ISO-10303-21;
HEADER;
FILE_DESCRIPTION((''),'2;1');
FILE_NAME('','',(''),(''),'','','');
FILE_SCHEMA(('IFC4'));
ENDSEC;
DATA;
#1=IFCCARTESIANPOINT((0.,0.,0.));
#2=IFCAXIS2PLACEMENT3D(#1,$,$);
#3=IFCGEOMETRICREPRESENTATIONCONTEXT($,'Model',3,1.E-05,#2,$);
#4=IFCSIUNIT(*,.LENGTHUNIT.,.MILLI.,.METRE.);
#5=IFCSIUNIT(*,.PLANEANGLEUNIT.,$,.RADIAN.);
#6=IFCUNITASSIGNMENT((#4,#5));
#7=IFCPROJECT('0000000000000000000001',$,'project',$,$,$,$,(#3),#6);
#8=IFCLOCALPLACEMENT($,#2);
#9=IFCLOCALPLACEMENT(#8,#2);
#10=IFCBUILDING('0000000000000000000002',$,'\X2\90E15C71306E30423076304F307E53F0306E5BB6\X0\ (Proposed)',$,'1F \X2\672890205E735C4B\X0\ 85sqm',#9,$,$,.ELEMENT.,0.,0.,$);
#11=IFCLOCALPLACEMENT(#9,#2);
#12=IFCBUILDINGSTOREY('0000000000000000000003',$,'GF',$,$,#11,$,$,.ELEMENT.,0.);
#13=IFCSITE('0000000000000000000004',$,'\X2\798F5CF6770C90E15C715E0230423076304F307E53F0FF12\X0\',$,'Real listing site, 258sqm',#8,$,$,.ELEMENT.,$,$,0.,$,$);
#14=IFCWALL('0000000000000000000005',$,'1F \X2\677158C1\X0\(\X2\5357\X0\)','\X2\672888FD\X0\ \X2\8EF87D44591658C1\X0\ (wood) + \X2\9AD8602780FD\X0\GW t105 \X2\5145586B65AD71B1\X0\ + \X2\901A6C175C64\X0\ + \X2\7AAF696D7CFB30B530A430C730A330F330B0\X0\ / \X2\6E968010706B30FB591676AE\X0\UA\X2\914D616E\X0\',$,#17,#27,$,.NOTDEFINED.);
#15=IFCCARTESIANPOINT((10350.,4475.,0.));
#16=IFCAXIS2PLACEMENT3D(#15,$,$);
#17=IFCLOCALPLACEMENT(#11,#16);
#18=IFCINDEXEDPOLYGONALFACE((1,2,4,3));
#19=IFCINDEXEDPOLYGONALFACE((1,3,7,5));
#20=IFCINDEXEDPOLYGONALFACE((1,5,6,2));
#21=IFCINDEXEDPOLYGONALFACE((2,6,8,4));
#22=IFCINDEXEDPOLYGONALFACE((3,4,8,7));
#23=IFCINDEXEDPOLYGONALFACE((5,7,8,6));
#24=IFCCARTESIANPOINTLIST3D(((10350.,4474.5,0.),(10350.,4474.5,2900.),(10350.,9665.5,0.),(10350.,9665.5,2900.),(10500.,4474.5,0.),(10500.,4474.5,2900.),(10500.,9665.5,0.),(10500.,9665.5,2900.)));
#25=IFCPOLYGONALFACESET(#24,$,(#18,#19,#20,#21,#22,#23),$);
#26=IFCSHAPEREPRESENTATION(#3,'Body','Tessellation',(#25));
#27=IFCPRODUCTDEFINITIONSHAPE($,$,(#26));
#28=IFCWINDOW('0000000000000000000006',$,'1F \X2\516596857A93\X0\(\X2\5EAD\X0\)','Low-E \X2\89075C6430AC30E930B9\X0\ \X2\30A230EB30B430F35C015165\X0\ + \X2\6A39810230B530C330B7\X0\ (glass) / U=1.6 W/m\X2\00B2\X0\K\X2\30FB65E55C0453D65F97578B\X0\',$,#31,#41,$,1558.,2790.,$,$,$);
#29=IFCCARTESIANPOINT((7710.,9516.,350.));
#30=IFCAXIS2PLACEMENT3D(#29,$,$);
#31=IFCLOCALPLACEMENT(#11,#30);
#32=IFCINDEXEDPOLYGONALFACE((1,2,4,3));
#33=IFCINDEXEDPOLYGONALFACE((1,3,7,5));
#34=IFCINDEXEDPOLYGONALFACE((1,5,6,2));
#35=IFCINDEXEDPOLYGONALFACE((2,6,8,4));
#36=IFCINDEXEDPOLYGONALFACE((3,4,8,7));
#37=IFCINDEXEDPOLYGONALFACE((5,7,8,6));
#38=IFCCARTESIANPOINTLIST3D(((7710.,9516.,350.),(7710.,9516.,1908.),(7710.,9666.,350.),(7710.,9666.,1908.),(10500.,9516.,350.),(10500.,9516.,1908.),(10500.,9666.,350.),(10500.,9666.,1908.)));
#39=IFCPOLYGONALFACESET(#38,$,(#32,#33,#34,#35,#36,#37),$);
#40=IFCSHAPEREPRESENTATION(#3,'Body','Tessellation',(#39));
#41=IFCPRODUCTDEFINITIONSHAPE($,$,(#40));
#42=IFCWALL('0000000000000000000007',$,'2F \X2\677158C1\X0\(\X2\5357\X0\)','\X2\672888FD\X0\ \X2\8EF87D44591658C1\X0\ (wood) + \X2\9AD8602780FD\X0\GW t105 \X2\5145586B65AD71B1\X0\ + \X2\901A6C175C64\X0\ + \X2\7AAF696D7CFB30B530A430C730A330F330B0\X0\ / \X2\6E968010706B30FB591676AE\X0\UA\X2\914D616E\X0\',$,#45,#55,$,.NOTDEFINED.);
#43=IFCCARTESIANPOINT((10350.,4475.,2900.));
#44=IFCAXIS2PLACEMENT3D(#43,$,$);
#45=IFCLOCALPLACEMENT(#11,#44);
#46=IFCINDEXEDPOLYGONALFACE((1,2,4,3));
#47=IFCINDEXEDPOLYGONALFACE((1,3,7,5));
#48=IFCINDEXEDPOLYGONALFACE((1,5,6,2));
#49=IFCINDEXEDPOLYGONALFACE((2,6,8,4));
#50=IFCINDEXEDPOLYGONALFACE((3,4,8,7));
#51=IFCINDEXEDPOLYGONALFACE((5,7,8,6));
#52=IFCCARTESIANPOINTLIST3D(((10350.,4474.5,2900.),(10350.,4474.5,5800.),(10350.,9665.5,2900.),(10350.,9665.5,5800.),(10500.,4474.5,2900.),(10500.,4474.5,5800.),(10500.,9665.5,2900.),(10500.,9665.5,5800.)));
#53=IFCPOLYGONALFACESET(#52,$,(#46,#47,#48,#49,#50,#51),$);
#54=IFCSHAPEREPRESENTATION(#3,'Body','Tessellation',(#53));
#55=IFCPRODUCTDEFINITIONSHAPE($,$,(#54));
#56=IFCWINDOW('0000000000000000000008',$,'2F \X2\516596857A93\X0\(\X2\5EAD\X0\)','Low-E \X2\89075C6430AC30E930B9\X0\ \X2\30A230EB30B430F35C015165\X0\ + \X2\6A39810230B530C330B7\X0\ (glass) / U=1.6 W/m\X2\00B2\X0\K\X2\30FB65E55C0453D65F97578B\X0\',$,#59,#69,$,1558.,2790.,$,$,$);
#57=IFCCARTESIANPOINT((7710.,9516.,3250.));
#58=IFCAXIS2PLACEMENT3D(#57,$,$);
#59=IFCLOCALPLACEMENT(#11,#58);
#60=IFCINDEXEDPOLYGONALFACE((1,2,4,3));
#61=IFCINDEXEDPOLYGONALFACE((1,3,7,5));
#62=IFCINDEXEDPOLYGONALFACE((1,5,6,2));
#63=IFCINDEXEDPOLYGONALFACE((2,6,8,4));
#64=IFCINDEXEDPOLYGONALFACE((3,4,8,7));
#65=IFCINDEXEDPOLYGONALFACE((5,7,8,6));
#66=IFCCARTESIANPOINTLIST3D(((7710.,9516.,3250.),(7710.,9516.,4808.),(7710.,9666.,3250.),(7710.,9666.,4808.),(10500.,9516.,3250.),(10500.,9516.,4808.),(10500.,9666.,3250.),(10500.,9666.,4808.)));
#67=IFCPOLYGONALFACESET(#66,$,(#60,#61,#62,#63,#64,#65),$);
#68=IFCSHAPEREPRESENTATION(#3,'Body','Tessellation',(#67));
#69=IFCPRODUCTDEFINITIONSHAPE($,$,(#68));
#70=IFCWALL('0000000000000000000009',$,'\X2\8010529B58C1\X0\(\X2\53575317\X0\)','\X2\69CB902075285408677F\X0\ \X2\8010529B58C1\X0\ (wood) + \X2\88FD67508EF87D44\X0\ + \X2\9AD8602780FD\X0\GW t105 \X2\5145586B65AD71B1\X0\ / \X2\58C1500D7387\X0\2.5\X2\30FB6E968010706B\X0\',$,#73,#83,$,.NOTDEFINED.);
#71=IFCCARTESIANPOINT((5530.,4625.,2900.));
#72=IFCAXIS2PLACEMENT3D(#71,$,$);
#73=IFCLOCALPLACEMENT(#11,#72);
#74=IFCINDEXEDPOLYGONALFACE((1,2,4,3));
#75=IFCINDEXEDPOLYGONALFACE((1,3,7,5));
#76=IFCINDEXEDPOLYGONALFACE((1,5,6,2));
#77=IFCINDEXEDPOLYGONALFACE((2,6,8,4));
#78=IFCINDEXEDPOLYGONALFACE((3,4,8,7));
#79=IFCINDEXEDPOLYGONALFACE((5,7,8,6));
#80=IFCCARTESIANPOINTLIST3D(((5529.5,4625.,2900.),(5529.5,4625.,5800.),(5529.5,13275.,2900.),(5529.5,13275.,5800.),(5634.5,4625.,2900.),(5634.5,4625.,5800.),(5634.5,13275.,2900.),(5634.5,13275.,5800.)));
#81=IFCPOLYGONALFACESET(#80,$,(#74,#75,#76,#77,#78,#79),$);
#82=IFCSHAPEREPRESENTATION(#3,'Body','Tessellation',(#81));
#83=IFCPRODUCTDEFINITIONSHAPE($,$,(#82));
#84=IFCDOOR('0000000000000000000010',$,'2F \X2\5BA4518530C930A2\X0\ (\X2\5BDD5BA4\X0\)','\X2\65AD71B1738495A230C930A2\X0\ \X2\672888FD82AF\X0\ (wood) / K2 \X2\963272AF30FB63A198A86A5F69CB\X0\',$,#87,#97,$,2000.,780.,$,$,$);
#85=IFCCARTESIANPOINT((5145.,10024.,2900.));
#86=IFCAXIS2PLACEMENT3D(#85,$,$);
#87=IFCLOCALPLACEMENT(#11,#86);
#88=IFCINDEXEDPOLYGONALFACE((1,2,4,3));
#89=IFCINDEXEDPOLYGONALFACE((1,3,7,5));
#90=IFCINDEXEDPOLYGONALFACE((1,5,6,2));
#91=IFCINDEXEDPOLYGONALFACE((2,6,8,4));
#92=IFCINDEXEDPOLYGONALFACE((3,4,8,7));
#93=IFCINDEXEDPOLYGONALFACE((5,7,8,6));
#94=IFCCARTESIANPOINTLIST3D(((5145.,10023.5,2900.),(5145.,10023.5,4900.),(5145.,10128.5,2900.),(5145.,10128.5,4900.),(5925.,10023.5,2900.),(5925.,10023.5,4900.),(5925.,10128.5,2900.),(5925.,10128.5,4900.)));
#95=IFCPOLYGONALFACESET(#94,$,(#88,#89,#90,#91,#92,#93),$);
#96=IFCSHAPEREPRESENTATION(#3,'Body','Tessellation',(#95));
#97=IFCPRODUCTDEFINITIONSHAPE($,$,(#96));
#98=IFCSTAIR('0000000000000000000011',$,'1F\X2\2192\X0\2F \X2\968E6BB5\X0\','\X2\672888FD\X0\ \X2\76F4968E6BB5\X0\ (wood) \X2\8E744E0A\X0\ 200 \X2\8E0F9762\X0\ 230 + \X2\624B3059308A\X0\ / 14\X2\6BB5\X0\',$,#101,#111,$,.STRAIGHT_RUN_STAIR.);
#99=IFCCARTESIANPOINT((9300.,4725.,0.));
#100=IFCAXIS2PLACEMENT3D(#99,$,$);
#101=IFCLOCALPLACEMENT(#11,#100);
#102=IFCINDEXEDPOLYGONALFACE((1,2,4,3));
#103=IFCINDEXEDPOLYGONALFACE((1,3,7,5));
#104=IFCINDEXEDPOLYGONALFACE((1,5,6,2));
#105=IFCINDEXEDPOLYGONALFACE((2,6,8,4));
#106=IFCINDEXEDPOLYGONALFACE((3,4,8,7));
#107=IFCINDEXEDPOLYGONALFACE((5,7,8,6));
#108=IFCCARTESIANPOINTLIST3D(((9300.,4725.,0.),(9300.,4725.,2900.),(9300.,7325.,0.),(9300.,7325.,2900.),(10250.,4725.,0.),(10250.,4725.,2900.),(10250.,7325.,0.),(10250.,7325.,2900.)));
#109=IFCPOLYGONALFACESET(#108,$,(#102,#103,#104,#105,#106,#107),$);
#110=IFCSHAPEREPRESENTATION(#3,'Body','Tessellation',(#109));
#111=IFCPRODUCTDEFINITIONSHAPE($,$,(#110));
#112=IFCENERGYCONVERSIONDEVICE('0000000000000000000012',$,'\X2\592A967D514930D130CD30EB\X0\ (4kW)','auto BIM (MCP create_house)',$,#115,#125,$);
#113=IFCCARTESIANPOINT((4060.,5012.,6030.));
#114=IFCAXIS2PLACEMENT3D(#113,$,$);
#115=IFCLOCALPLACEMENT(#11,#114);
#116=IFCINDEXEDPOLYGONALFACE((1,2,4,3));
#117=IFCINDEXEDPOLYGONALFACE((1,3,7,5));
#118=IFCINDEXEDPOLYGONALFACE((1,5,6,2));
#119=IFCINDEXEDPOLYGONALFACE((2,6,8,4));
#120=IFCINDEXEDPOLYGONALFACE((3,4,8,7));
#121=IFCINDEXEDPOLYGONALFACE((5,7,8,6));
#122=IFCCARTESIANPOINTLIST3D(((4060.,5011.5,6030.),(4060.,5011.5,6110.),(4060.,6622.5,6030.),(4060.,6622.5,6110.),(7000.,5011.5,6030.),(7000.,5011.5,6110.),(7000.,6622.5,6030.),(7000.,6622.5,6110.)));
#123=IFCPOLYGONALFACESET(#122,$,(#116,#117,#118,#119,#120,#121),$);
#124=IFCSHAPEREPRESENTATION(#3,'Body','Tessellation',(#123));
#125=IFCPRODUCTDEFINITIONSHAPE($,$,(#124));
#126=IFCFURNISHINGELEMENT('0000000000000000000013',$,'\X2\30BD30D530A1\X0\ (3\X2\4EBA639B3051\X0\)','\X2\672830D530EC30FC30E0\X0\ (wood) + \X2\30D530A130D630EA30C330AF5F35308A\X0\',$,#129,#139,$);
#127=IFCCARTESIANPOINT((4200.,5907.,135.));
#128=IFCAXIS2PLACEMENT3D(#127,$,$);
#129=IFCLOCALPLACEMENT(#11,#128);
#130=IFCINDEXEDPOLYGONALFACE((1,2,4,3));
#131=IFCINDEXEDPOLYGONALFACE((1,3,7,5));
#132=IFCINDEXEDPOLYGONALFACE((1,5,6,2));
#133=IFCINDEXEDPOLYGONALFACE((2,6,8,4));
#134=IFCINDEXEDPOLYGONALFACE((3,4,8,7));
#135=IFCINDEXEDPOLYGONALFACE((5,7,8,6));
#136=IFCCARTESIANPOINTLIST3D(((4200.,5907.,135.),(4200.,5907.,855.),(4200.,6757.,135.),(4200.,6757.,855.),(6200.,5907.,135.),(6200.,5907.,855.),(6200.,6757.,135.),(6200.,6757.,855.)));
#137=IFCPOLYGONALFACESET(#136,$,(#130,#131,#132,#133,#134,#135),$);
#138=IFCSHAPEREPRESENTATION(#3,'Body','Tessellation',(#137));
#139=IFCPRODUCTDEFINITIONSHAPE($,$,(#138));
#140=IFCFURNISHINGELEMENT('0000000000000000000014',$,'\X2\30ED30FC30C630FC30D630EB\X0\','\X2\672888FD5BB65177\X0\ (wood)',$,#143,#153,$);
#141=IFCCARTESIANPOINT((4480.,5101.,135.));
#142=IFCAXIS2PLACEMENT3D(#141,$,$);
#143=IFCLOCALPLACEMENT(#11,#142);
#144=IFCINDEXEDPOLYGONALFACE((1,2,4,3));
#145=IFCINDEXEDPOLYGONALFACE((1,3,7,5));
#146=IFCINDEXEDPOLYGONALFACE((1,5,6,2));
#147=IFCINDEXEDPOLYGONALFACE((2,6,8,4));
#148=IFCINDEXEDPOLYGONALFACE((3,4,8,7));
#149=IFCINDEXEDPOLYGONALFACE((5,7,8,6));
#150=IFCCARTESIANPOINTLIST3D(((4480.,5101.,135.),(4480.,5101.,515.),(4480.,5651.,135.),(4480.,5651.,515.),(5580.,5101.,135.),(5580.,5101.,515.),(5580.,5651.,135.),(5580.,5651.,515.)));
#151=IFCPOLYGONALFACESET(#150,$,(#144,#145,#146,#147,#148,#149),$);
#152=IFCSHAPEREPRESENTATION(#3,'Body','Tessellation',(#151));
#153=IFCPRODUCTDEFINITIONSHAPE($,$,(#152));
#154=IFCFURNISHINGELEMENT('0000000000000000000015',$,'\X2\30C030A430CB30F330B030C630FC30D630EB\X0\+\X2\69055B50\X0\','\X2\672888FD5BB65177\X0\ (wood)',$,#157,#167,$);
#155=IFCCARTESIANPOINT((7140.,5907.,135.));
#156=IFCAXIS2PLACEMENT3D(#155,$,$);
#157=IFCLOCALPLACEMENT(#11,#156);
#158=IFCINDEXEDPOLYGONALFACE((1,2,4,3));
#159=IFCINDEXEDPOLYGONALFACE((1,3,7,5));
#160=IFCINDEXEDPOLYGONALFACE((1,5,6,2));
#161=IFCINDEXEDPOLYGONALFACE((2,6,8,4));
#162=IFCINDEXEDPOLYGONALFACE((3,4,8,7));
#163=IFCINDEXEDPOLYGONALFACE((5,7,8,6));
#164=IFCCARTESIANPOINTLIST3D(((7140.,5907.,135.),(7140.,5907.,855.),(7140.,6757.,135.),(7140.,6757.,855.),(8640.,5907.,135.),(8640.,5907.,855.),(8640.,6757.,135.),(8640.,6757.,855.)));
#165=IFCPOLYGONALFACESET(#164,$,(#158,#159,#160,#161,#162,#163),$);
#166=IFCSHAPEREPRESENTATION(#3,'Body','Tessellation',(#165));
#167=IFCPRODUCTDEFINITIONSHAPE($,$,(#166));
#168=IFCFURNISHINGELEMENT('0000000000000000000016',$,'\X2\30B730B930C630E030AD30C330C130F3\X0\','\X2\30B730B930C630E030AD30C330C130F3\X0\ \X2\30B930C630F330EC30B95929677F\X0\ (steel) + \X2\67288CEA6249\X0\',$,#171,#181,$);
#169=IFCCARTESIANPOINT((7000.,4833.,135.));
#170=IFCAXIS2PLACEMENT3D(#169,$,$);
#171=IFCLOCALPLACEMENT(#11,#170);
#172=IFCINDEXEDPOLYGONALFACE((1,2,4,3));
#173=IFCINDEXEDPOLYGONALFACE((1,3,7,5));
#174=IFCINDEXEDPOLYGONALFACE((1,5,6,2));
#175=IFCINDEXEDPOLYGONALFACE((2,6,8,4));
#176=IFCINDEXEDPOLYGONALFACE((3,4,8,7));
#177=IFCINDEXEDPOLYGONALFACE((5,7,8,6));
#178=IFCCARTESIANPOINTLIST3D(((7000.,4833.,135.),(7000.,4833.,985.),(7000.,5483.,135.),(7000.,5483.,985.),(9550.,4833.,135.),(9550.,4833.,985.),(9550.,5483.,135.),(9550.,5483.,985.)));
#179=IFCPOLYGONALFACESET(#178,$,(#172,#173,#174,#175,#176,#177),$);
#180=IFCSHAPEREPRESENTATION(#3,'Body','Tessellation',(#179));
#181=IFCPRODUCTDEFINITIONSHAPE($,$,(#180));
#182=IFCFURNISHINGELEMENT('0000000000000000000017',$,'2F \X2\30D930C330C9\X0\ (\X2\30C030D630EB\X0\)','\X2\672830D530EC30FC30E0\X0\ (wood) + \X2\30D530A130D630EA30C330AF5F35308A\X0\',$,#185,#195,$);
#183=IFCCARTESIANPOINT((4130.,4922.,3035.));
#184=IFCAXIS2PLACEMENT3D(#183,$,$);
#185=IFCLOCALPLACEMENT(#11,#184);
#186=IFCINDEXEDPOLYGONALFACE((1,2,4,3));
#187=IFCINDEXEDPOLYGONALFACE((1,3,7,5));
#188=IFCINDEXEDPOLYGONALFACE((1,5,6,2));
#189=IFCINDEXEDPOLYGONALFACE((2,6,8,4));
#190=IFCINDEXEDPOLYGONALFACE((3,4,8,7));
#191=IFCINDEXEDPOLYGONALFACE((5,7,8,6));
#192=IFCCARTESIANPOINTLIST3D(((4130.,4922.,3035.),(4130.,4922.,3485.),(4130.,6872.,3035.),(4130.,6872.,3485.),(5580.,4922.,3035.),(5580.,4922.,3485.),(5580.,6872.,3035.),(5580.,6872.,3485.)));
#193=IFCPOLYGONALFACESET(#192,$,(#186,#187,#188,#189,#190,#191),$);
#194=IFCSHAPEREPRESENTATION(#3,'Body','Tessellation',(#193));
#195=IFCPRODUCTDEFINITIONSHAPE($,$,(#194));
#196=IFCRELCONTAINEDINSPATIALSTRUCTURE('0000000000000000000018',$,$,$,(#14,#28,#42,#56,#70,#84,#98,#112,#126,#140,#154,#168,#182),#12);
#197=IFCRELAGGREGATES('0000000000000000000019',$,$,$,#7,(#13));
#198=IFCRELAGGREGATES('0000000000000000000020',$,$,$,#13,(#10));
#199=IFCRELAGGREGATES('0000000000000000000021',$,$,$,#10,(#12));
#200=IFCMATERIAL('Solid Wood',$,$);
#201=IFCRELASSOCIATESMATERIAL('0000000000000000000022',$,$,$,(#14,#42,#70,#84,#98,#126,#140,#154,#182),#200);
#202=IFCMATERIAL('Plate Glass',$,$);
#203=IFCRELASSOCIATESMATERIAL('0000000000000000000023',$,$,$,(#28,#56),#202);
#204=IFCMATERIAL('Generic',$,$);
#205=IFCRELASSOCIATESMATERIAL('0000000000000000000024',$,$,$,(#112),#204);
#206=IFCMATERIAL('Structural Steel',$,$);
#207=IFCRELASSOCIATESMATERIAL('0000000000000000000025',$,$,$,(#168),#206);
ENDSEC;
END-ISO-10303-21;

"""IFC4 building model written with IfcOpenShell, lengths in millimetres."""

from ifc_helpers import new_model, si_unit, frame, frame_2d, origin, place, context, project, spatial, rectangle, extrude, material, element, fill, save


model = new_model("IFC4")

# Units and contexts
model_context = context("Model", 3, precision=1e-05, world=origin())
ifc_project = project(units=[si_unit("LENGTHUNIT", "METRE", prefix="MILLI"), si_unit("PLANEANGLEUNIT", "RADIAN")], contexts=[model_context])

# Site, building, storey
site_placement = place(None, origin())
site = spatial("IfcSite", under=ifc_project, at=site_placement, Name="福島県郡山市あぶくま台２", ObjectType="Real listing site, 258sqm", CompositionType="ELEMENT", RefElevation=0.0)
building_placement = place(site_placement, origin())
building = spatial("IfcBuilding", under=site, at=building_placement, Name="郡山のあぶくま台の家 (Proposed)", ObjectType="1F 木造平屋 85sqm", CompositionType="ELEMENT", ElevationOfRefHeight=0.0, ElevationOfTerrain=0.0)
storey_placement = place(building_placement, origin())
storey = spatial("IfcBuildingStorey", under=building, at=storey_placement, Name="GF", CompositionType="ELEMENT", Elevation=0.0)

# Wall, opening, window
ifc_material_1 = material(Name="Solid Wood")
wall_1_placement = place(storey_placement, frame((10350.0, 4475.0, 0.0)))
wall_1 = element("IfcWall", 1, at=wall_1_placement, inside=storey, material=ifc_material_1, Name="1F 東壁(南)", Description="木製 軸組外壁 (wood) + 高性能GW t105 充填断熱 + 通気層 + 窯業系サイディング / 準耐火・外皮UA配慮", PredefinedType="NOTDEFINED", context=model_context, shape_type="SweptSolid", body=[
    extrude(rectangle(XDim=150.0, YDim=5191.0, at=frame_2d((75.0, 2595.0))), frame((10350.0, 4475.0, 0.0)), (0.0, 0.0, 1.0), 2900.0),
])
opening_1_placement = place(storey_placement, frame((7710.0, 9516.0, 350.0)))
opening_1 = element("IfcOpeningElement", 2, at=opening_1_placement, cuts=wall_1, PredefinedType="NOTDEFINED", context=model_context, shape_type="SweptSolid", body=[
    extrude(rectangle(XDim=2790.0, YDim=150.0, at=frame_2d((1395.0, 75.0))), frame((7710.0, 9516.0, 350.0)), (0.0, 0.0, 1.0), 1558.0),
])
ifc_material_2 = material(Name="Plate Glass")
window_1_placement = place(storey_placement, frame((7710.0, 9516.0, 350.0)))
window_1 = element("IfcWindow", 3, at=window_1_placement, inside=storey, material=ifc_material_2, Name="1F 入隅窓(庭)", Description="Low-E 複層ガラス アルゴン封入 + 樹脂サッシ (glass) / U=1.6 W/m²K・日射取得型", OverallHeight=1558.0, OverallWidth=2790.0, context=model_context, shape_type="SweptSolid", body=[
    extrude(rectangle(XDim=2790.0, YDim=150.0, at=frame_2d((1395.0, 75.0))), frame((7710.0, 9516.0, 350.0)), (0.0, 0.0, 1.0), 1558.0),
])
fill(opening_1, window_1)

# Wall, opening, window
wall_2_placement = place(storey_placement, frame((10350.0, 4475.0, 2900.0)))
wall_2 = element("IfcWall", 4, at=wall_2_placement, inside=storey, material=ifc_material_1, Name="2F 東壁(南)", Description="木製 軸組外壁 (wood) + 高性能GW t105 充填断熱 + 通気層 + 窯業系サイディング / 準耐火・外皮UA配慮", PredefinedType="NOTDEFINED", context=model_context, shape_type="SweptSolid", body=[
    extrude(rectangle(XDim=150.0, YDim=5191.0, at=frame_2d((75.0, 2595.0))), frame((10350.0, 4475.0, 2900.0)), (0.0, 0.0, 1.0), 2900.0),
])
opening_2_placement = place(storey_placement, frame((7710.0, 9516.0, 3250.0)))
opening_2 = element("IfcOpeningElement", 5, at=opening_2_placement, cuts=wall_2, PredefinedType="NOTDEFINED", context=model_context, shape_type="SweptSolid", body=[
    extrude(rectangle(XDim=2790.0, YDim=150.0, at=frame_2d((1395.0, 75.0))), frame((7710.0, 9516.0, 3250.0)), (0.0, 0.0, 1.0), 1558.0),
])
window_2_placement = place(storey_placement, frame((7710.0, 9516.0, 3250.0)))
window_2 = element("IfcWindow", 6, at=window_2_placement, inside=storey, material=ifc_material_2, Name="2F 入隅窓(庭)", Description="Low-E 複層ガラス アルゴン封入 + 樹脂サッシ (glass) / U=1.6 W/m²K・日射取得型", OverallHeight=1558.0, OverallWidth=2790.0, context=model_context, shape_type="SweptSolid", body=[
    extrude(rectangle(XDim=2790.0, YDim=150.0, at=frame_2d((1395.0, 75.0))), frame((7710.0, 9516.0, 3250.0)), (0.0, 0.0, 1.0), 1558.0),
])
fill(opening_2, window_2)

# Wall, opening, door
wall_3_placement = place(storey_placement, frame((5530.0, 4625.0, 2900.0)))
wall_3 = element("IfcWall", 7, at=wall_3_placement, inside=storey, material=ifc_material_1, Name="耐力壁(南北)", Description="構造用合板 耐力壁 (wood) + 製材軸組 + 高性能GW t105 充填断熱 / 壁倍率2.5・準耐火", PredefinedType="NOTDEFINED", context=model_context, shape_type="SweptSolid", body=[
    extrude(rectangle(XDim=105.0, YDim=8650.0, at=frame_2d((52.0, 4325.0))), frame((5530.0, 4625.0, 2900.0)), (0.0, 0.0, 1.0), 2900.0),
])
opening_3_placement = place(storey_placement, frame((5145.0, 10024.0, 2900.0)))
opening_3 = element("IfcOpeningElement", 8, at=opening_3_placement, cuts=wall_3, PredefinedType="NOTDEFINED", context=model_context, shape_type="SweptSolid", body=[
    extrude(rectangle(XDim=780.0, YDim=105.0, at=frame_2d((390.0, 52.0))), frame((5145.0, 10024.0, 2900.0)), (0.0, 0.0, 1.0), 2000.0),
])
door_1_placement = place(storey_placement, frame((5145.0, 10024.0, 2900.0)))
door_1 = element("IfcDoor", 9, at=door_1_placement, inside=storey, material=ifc_material_1, Name="2F 室内ドア (寝室)", Description="断熱玄関ドア 木製芯 (wood) / K2 防犯・採風機構", OverallHeight=2000.0, OverallWidth=780.0, context=model_context, shape_type="SweptSolid", body=[
    extrude(rectangle(XDim=780.0, YDim=105.0, at=frame_2d((390.0, 52.0))), frame((5145.0, 10024.0, 2900.0)), (0.0, 0.0, 1.0), 2000.0),
])
fill(opening_3, door_1)

# Stair
stair_placement = place(storey_placement, frame((9300.0, 4725.0, 0.0)))
element("IfcStair", 10, at=stair_placement, inside=storey, material=ifc_material_1, Name="1F→2F 階段", Description="木製 直階段 (wood) 蹴上 200 踏面 230 + 手すり / 14段", PredefinedType="STRAIGHT_RUN_STAIR", context=model_context, shape_type="SweptSolid", body=[
    extrude(rectangle(XDim=950.0, YDim=2600.0, at=frame_2d((475.0, 1300.0))), frame((9300.0, 4725.0, 0.0)), (0.0, 0.0, 1.0), 2900.0),
])

# Energy conversion device
ifc_material_3 = material(Name="Generic")
energy_conversion_device_placement = place(storey_placement, frame((4060.0, 5012.0, 6030.0)))
element("IfcEnergyConversionDevice", 11, at=energy_conversion_device_placement, inside=storey, material=ifc_material_3, Name="太陽光パネル (4kW)", Description="auto BIM (MCP create_house)", context=model_context, shape_type="SweptSolid", body=[
    extrude(rectangle(XDim=2940.0, YDim=1611.0, at=frame_2d((1470.0, 805.0))), frame((4060.0, 5012.0, 6030.0)), (0.0, 0.0, 1.0), 80.0),
])

# Furnishing elements
furnishing_1_placement = place(storey_placement, frame((4200.0, 5907.0, 135.0)))
element("IfcFurnishingElement", 12, at=furnishing_1_placement, inside=storey, material=ifc_material_1, Name="ソファ (3人掛け)", Description="木フレーム (wood) + ファブリック張り", context=model_context, shape_type="SweptSolid", body=[
    extrude(rectangle(XDim=2000.0, YDim=850.0, at=frame_2d((1000.0, 425.0))), frame((4200.0, 5907.0, 135.0)), (0.0, 0.0, 1.0), 720.0),
])
furnishing_2_placement = place(storey_placement, frame((4480.0, 5101.0, 135.0)))
element("IfcFurnishingElement", 13, at=furnishing_2_placement, inside=storey, material=ifc_material_1, Name="ローテーブル", Description="木製家具 (wood)", context=model_context, shape_type="SweptSolid", body=[
    extrude(rectangle(XDim=1100.0, YDim=550.0, at=frame_2d((550.0, 275.0))), frame((4480.0, 5101.0, 135.0)), (0.0, 0.0, 1.0), 380.0),
])
furnishing_3_placement = place(storey_placement, frame((7140.0, 5907.0, 135.0)))
element("IfcFurnishingElement", 14, at=furnishing_3_placement, inside=storey, material=ifc_material_1, Name="ダイニングテーブル+椅子", Description="木製家具 (wood)", context=model_context, shape_type="SweptSolid", body=[
    extrude(rectangle(XDim=1500.0, YDim=850.0, at=frame_2d((750.0, 425.0))), frame((7140.0, 5907.0, 135.0)), (0.0, 0.0, 1.0), 720.0),
])
ifc_material_4 = material(Name="Structural Steel")
furnishing_4_placement = place(storey_placement, frame((7000.0, 4833.0, 135.0)))
element("IfcFurnishingElement", 15, at=furnishing_4_placement, inside=storey, material=ifc_material_4, Name="システムキッチン", Description="システムキッチン ステンレス天板 (steel) + 木質扉", context=model_context, shape_type="SweptSolid", body=[
    extrude(rectangle(XDim=2550.0, YDim=650.0, at=frame_2d((1275.0, 325.0))), frame((7000.0, 4833.0, 135.0)), (0.0, 0.0, 1.0), 850.0),
])
furnishing_5_placement = place(storey_placement, frame((4130.0, 4922.0, 3035.0)))
element("IfcFurnishingElement", 16, at=furnishing_5_placement, inside=storey, material=ifc_material_1, Name="2F ベッド (ダブル)", Description="木フレーム (wood) + ファブリック張り", context=model_context, shape_type="SweptSolid", body=[
    extrude(rectangle(XDim=1450.0, YDim=1950.0, at=frame_2d((725.0, 975.0))), frame((4130.0, 4922.0, 3035.0)), (0.0, 0.0, 1.0), 450.0),
])

save(model, "model.ifc")
